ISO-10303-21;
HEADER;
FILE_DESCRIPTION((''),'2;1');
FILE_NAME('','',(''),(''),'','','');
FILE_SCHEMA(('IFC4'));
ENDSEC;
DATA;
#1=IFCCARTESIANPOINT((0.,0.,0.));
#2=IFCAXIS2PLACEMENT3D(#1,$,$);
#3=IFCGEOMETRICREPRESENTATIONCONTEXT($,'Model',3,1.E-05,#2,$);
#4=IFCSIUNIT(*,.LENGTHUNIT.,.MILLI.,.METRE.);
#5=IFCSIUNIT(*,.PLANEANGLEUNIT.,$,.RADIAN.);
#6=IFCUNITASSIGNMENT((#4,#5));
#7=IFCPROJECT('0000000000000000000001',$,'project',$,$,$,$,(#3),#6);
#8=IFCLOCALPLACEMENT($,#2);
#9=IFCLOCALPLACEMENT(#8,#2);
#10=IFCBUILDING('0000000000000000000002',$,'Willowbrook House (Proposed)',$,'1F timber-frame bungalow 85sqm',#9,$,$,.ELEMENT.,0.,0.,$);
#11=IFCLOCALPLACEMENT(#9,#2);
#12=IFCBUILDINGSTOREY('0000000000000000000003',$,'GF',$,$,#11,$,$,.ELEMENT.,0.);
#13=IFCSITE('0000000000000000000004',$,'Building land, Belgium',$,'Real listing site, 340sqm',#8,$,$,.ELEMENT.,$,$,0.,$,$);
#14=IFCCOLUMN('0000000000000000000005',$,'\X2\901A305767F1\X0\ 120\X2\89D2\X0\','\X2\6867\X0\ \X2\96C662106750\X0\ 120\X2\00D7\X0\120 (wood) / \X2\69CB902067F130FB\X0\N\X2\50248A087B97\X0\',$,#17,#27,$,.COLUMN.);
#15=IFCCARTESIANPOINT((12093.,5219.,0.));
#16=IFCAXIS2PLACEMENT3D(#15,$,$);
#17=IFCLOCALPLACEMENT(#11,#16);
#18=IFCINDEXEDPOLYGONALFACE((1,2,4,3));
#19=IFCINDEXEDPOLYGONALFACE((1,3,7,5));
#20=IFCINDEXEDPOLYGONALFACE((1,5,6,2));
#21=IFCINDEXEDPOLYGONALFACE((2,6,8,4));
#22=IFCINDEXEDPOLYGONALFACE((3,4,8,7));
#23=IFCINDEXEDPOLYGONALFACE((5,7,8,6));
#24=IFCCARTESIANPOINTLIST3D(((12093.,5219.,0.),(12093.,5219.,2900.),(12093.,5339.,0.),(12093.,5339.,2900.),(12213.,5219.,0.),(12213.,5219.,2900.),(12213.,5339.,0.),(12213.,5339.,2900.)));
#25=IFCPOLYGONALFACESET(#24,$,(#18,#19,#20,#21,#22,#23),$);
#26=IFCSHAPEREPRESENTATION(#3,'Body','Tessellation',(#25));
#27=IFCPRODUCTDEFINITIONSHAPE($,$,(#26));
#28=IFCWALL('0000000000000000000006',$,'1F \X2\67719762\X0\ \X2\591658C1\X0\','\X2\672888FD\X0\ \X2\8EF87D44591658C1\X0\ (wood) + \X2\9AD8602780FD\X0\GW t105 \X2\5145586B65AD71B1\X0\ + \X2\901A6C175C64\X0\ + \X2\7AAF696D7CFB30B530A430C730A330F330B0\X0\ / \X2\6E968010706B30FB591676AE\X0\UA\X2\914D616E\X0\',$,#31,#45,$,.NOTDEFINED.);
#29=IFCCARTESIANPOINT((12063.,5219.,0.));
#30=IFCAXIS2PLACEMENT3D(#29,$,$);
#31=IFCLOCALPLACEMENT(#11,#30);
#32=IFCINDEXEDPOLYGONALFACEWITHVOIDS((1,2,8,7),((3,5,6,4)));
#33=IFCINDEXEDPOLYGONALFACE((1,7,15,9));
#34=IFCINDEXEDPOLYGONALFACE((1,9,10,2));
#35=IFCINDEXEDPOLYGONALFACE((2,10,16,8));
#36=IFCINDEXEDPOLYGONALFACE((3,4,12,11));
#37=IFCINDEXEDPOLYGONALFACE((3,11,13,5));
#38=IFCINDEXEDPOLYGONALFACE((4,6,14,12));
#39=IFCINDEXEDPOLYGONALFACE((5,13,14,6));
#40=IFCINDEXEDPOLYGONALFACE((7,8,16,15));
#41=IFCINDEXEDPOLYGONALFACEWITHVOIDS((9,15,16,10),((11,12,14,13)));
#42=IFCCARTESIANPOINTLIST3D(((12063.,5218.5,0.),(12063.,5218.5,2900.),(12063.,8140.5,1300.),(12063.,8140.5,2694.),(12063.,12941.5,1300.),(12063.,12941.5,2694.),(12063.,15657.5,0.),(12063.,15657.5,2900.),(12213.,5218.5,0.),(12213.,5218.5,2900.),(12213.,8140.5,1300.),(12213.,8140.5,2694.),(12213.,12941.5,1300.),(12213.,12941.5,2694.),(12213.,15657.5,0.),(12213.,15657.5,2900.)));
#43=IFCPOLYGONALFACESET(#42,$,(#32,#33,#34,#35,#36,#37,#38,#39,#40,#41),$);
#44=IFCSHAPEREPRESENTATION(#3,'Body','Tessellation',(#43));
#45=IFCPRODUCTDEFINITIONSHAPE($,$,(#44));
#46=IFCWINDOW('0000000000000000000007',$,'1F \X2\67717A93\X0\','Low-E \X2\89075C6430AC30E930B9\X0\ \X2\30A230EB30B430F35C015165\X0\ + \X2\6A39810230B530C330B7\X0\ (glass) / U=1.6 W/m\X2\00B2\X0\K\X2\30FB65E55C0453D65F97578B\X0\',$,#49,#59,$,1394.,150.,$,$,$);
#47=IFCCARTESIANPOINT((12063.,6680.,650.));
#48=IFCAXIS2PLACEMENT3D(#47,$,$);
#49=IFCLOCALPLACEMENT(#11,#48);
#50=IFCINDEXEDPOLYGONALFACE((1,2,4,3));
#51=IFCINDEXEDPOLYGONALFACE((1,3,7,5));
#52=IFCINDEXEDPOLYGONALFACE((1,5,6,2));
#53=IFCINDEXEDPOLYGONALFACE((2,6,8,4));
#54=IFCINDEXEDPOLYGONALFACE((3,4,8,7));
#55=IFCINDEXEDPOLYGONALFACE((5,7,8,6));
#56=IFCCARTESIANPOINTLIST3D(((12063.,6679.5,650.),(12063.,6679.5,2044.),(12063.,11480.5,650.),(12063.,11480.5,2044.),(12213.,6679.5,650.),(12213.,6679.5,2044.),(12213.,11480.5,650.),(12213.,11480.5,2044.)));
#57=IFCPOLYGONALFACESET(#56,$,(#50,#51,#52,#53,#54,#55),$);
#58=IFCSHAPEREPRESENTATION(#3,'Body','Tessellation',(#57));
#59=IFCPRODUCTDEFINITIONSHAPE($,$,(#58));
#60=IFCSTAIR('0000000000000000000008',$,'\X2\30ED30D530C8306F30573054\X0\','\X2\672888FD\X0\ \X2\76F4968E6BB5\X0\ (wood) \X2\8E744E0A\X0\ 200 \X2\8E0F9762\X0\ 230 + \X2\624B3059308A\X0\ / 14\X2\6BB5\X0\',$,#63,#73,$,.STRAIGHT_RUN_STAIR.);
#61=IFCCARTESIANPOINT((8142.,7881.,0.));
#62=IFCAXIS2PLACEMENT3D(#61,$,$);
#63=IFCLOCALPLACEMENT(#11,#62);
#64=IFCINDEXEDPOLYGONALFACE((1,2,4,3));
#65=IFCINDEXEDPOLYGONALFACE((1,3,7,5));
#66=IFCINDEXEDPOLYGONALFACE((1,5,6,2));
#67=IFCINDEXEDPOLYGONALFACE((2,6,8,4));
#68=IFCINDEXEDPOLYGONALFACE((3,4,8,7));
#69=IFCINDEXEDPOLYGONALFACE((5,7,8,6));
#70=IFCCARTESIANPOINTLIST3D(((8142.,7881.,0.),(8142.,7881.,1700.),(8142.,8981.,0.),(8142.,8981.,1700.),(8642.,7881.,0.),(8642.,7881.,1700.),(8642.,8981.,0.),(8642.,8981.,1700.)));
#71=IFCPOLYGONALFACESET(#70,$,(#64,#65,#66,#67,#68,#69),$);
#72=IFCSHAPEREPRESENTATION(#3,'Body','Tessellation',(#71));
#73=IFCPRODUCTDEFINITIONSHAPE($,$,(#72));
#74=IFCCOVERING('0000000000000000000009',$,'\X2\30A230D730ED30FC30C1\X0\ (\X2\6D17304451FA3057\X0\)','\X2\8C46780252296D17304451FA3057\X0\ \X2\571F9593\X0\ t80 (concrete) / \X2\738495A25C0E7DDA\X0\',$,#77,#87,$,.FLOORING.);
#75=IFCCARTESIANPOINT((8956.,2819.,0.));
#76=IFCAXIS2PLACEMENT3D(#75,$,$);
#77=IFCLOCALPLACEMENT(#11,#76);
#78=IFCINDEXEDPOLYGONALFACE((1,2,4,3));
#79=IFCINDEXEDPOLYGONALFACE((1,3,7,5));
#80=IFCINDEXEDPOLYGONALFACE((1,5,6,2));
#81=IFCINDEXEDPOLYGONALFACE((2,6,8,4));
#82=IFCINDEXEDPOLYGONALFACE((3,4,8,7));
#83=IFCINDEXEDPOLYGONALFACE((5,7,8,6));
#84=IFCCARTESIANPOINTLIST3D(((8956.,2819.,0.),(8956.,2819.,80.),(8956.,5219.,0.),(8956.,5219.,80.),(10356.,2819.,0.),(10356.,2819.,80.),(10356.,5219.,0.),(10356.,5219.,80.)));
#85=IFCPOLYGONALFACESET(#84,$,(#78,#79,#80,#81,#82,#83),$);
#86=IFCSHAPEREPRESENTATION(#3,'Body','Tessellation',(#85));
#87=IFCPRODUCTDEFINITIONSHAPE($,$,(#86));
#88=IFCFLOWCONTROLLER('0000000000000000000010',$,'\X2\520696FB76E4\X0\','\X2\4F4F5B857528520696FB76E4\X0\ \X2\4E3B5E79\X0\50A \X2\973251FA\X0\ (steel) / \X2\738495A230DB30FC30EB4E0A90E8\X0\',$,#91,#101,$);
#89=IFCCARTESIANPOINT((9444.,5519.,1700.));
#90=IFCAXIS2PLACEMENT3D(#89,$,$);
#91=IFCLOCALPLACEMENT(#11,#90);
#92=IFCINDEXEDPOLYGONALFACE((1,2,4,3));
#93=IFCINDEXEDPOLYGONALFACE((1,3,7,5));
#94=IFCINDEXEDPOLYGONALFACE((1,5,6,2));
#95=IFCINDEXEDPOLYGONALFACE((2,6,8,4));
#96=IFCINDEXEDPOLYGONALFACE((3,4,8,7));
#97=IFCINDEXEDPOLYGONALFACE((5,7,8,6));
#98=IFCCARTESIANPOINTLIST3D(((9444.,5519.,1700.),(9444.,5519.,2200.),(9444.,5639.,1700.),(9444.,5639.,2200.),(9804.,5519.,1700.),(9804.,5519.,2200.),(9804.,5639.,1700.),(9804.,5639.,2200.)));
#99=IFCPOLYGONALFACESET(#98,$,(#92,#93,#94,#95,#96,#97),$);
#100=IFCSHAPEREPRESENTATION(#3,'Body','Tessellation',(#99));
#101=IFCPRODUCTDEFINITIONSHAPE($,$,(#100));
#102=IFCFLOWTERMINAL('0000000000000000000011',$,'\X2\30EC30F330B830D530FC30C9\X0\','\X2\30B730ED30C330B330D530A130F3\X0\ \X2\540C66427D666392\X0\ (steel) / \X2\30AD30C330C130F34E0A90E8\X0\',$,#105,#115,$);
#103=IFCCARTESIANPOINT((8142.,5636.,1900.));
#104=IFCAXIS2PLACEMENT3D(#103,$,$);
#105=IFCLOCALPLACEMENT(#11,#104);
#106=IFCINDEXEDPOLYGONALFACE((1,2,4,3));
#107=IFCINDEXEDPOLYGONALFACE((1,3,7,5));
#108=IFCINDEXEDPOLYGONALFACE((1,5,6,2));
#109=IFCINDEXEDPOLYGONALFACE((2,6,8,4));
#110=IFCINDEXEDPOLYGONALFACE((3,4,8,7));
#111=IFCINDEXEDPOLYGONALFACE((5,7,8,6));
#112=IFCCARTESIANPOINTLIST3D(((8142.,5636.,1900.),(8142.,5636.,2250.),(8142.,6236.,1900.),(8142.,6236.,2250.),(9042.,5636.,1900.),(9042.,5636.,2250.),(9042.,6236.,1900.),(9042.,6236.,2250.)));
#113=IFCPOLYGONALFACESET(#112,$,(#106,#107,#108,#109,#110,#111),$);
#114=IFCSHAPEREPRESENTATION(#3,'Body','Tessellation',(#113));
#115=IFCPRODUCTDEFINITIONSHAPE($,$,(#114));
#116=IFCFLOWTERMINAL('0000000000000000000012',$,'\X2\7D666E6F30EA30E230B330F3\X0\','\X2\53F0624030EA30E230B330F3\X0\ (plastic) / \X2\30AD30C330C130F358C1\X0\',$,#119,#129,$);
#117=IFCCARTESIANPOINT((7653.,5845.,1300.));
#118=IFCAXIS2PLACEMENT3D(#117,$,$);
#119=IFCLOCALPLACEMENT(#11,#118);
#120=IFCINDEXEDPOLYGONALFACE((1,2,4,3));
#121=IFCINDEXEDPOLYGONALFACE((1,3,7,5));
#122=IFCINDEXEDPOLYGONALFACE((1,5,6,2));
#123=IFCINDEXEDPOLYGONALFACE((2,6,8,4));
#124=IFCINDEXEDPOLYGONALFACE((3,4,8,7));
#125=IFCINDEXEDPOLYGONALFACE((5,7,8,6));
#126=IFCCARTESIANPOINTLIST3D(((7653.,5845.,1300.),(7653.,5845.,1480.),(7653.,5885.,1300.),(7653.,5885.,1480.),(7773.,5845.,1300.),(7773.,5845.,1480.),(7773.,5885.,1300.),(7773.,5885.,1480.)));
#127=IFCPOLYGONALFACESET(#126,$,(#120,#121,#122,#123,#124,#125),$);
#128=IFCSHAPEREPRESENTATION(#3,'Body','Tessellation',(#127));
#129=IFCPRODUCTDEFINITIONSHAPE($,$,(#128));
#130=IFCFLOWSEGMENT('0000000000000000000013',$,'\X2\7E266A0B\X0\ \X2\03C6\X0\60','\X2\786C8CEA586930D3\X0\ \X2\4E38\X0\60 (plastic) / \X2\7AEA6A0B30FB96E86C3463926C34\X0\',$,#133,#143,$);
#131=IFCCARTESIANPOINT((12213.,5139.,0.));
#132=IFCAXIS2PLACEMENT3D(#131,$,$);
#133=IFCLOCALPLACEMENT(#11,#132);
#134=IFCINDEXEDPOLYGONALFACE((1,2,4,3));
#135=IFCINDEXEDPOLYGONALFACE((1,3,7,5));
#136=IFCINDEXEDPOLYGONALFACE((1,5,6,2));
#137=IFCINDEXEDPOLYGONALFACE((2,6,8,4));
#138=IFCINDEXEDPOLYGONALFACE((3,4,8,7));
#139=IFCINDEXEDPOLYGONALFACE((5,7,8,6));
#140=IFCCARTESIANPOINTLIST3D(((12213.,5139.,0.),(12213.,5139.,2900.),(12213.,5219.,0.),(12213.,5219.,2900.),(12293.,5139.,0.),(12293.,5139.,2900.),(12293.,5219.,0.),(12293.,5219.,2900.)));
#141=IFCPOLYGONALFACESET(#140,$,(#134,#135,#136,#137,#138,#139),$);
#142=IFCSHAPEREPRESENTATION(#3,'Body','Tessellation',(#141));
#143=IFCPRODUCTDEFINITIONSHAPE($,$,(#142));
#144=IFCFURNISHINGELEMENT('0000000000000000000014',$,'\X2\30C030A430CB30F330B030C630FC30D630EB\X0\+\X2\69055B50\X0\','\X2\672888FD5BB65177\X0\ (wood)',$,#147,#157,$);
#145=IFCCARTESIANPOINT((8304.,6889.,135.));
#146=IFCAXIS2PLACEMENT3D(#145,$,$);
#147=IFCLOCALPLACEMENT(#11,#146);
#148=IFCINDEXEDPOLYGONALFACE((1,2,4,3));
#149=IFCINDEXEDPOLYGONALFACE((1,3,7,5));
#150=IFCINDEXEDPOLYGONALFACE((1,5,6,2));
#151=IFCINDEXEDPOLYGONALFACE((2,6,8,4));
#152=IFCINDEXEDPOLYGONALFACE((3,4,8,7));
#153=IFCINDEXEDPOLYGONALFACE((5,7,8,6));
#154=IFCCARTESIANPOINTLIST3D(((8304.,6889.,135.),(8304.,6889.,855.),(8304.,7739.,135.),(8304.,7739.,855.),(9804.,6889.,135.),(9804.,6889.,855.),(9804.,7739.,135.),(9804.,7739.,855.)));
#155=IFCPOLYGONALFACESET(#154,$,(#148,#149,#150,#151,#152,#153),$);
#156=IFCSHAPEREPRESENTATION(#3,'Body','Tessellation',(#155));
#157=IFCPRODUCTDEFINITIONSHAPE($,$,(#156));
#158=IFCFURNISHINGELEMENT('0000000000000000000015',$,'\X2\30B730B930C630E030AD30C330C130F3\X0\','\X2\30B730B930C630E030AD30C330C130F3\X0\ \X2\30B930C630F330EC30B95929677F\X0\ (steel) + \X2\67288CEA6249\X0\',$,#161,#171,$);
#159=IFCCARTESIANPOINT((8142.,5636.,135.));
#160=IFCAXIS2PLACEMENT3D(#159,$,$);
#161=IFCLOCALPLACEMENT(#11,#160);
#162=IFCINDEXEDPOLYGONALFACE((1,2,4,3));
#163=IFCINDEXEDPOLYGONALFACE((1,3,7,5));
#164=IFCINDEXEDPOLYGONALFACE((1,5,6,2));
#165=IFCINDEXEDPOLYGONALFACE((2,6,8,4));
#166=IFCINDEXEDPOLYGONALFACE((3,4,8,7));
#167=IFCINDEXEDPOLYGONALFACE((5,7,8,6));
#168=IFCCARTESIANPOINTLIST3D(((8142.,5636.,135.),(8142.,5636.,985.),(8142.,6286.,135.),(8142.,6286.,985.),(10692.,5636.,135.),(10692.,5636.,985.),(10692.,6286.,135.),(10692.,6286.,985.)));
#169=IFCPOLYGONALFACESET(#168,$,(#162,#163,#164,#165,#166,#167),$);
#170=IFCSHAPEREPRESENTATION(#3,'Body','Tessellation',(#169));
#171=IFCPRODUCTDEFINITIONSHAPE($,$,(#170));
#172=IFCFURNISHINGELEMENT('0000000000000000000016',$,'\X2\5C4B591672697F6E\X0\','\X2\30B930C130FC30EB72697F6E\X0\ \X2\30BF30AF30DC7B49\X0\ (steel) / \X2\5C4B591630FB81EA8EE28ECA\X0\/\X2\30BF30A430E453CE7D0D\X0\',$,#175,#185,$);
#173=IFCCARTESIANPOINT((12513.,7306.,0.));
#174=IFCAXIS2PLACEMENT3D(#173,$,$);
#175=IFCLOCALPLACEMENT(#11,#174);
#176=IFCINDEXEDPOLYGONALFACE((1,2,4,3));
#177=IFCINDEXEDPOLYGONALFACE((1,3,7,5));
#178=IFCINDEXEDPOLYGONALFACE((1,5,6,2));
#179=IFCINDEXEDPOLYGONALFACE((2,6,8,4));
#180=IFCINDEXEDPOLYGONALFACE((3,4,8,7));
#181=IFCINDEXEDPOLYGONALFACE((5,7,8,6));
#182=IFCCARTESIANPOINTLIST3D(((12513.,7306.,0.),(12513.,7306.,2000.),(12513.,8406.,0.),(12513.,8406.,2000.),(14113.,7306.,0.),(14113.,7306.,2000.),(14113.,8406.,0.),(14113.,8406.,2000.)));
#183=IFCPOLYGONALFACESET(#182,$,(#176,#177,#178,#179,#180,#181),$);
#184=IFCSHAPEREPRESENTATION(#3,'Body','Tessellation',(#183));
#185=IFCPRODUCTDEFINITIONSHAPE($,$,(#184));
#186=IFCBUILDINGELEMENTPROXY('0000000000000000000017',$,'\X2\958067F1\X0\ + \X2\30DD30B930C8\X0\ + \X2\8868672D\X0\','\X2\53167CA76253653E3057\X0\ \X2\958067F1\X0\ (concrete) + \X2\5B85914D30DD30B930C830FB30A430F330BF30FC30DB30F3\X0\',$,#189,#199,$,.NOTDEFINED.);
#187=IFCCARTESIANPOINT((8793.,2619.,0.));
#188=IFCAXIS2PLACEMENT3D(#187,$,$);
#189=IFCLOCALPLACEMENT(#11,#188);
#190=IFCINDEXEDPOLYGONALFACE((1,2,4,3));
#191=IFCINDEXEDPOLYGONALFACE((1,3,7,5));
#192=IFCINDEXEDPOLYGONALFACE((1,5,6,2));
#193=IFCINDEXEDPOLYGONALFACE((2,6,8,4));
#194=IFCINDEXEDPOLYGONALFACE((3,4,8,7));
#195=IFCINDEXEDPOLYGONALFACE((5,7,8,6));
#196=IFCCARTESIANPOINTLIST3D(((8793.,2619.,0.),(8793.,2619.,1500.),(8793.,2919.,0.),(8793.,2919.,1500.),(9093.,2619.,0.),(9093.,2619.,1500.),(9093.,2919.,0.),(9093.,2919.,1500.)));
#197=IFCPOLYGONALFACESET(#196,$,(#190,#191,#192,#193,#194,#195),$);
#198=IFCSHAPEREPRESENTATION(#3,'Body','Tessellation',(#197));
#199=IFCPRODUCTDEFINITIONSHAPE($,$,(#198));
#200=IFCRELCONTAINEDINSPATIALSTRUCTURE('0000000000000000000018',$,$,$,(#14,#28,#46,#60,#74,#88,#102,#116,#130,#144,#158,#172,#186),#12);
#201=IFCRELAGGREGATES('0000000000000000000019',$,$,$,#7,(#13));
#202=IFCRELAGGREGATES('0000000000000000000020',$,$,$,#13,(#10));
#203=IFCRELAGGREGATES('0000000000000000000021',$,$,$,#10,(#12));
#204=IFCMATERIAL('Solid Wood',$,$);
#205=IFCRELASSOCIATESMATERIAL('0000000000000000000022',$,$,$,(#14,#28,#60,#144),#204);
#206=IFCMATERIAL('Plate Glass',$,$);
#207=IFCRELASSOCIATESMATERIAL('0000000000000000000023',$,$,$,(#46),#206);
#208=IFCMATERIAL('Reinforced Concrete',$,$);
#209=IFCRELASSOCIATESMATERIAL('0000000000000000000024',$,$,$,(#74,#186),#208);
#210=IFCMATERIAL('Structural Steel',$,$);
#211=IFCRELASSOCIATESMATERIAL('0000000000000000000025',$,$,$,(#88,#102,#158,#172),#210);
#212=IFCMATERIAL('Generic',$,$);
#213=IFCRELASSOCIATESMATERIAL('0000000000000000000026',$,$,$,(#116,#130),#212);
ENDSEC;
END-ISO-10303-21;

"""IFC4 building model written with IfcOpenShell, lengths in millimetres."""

from ifc_helpers import new_model, si_unit, frame, frame_2d, origin, place, context, project, spatial, rectangle, extrude, material, element, fill, save


model = new_model("IFC4")

# Units and contexts
model_context = context("Model", 3, precision=1e-05, world=origin())
ifc_project = project(units=[si_unit("LENGTHUNIT", "METRE", prefix="MILLI"), si_unit("PLANEANGLEUNIT", "RADIAN")], contexts=[model_context])

# Site, building, storey
site_placement = place(None, origin())
site = spatial("IfcSite", under=ifc_project, at=site_placement, Name="Building land, Belgium", ObjectType="Real listing site, 340sqm", CompositionType="ELEMENT", RefElevation=0.0)
building_placement = place(site_placement, origin())
building = spatial("IfcBuilding", under=site, at=building_placement, Name="Willowbrook House (Proposed)", ObjectType="1F timber-frame bungalow 85sqm", CompositionType="ELEMENT", ElevationOfRefHeight=0.0, ElevationOfTerrain=0.0)
storey_placement = place(building_placement, origin())
storey = spatial("IfcBuildingStorey", under=building, at=storey_placement, Name="GF", CompositionType="ELEMENT", Elevation=0.0)

# Column
ifc_material_1 = material(Name="Solid Wood")
column_1_placement = place(storey_placement, frame((12093.0, 5219.0, 0.0)))
element("IfcColumn", 1, at=column_1_placement, inside=storey, material=ifc_material_1, Name="通し柱 120角", Description="桧 集成材 120×120 (wood) / 構造柱・N値計算", PredefinedType="COLUMN", context=model_context, shape_type="SweptSolid", body=[
    extrude(rectangle(XDim=120.0, YDim=120.0, at=frame_2d((60.0, 60.0))), frame((12093.0, 5219.0, 0.0)), (0.0, 0.0, 1.0), 2900.0),
])

# Wall, opening, window
wall_1_placement = place(storey_placement, frame((12063.0, 5219.0, 0.0)))
wall_1 = element("IfcWall", 2, at=wall_1_placement, inside=storey, material=ifc_material_1, Name="1F 東面 外壁", Description="木製 軸組外壁 (wood) + 高性能GW t105 充填断熱 + 通気層 + 窯業系サイディング / 準耐火・外皮UA配慮", PredefinedType="NOTDEFINED", context=model_context, shape_type="SweptSolid", body=[
    extrude(rectangle(XDim=150.0, YDim=10439.0, at=frame_2d((75.0, 5219.0))), frame((12063.0, 5219.0, 0.0)), (0.0, 0.0, 1.0), 2900.0),
])
opening_placement = place(storey_placement, frame((12063.0, 6680.0, 650.0)))
opening = element("IfcOpeningElement", 3, at=opening_placement, cuts=wall_1, PredefinedType="NOTDEFINED", context=model_context, shape_type="SweptSolid", body=[
    extrude(rectangle(XDim=150.0, YDim=4801.0, at=frame_2d((75.0, 2400.0))), frame((12063.0, 6680.0, 650.0)), (0.0, 0.0, 1.0), 1394.0),
])
ifc_material_2 = material(Name="Plate Glass")
window_placement = place(storey_placement, frame((12063.0, 6680.0, 650.0)))
window = element("IfcWindow", 4, at=window_placement, inside=storey, material=ifc_material_2, Name="1F 東窓", Description="Low-E 複層ガラス アルゴン封入 + 樹脂サッシ (glass) / U=1.6 W/m²K・日射取得型", OverallHeight=1394.0, OverallWidth=150.0, context=model_context, shape_type="SweptSolid", body=[
    extrude(rectangle(XDim=150.0, YDim=4801.0, at=frame_2d((75.0, 2400.0))), frame((12063.0, 6680.0, 650.0)), (0.0, 0.0, 1.0), 1394.0),
])
fill(opening, window)

# Stair
stair_placement = place(storey_placement, frame((8142.0, 7881.0, 0.0)))
element("IfcStair", 5, at=stair_placement, inside=storey, material=ifc_material_1, Name="ロフトはしご", Description="木製 直階段 (wood) 蹴上 200 踏面 230 + 手すり / 14段", PredefinedType="STRAIGHT_RUN_STAIR", context=model_context, shape_type="SweptSolid", body=[
    extrude(rectangle(XDim=500.0, YDim=1100.0, at=frame_2d((250.0, 550.0))), frame((8142.0, 7881.0, 0.0)), (0.0, 0.0, 1.0), 1700.0),
])

# Covering
ifc_material_3 = material(Name="Reinforced Concrete")
covering_placement = place(storey_placement, frame((8956.0, 2819.0, 0.0)))
element("IfcCovering", 6, at=covering_placement, inside=storey, material=ifc_material_3, Name="アプローチ (洗い出し)", Description="豆砂利洗い出し 土間 t80 (concrete) / 玄関導線", PredefinedType="FLOORING", context=model_context, shape_type="SweptSolid", body=[
    extrude(rectangle(XDim=1400.0, YDim=2400.0, at=frame_2d((700.0, 1200.0))), frame((8956.0, 2819.0, 0.0)), (0.0, 0.0, 1.0), 80.0),
])

# Flow controller
ifc_material_4 = material(Name="Structural Steel")
flow_controller_placement = place(storey_placement, frame((9444.0, 5519.0, 1700.0)))
element("IfcFlowController", 7, at=flow_controller_placement, inside=storey, material=ifc_material_4, Name="分電盤", Description="住宅用分電盤 主幹50A 露出 (steel) / 玄関ホール上部", context=model_context, shape_type="SweptSolid", body=[
    extrude(rectangle(XDim=360.0, YDim=120.0, at=frame_2d((180.0, 60.0))), frame((9444.0, 5519.0, 1700.0)), (0.0, 0.0, 1.0), 500.0),
])

# Flow terminals
flow_terminal_1_placement = place(storey_placement, frame((8142.0, 5636.0, 1900.0)))
element("IfcFlowTerminal", 8, at=flow_terminal_1_placement, inside=storey, material=ifc_material_4, Name="レンジフード", Description="シロッコファン 同時給排 (steel) / キッチン上部", context=model_context, shape_type="SweptSolid", body=[
    extrude(rectangle(XDim=900.0, YDim=600.0, at=frame_2d((450.0, 300.0))), frame((8142.0, 5636.0, 1900.0)), (0.0, 0.0, 1.0), 350.0),
])
ifc_material_5 = material(Name="Generic")
flow_terminal_2_placement = place(storey_placement, frame((7653.0, 5845.0, 1300.0)))
element("IfcFlowTerminal", 9, at=flow_terminal_2_placement, inside=storey, material=ifc_material_5, Name="給湯リモコン", Description="台所リモコン (plastic) / キッチン壁", context=model_context, shape_type="SweptSolid", body=[
    extrude(rectangle(XDim=120.0, YDim=40.0, at=frame_2d((60.0, 20.0))), frame((7653.0, 5845.0, 1300.0)), (0.0, 0.0, 1.0), 180.0),
])

# Flow segment
flow_segment_placement = place(storey_placement, frame((12213.0, 5139.0, 0.0)))
element("IfcFlowSegment", 10, at=flow_segment_placement, inside=storey, material=ifc_material_5, Name="縦樋 φ60", Description="硬質塩ビ 丸60 (plastic) / 竪樋・雨水排水", context=model_context, shape_type="SweptSolid", body=[
    extrude(rectangle(XDim=80.0, YDim=80.0, at=frame_2d((40.0, 40.0))), frame((12213.0, 5139.0, 0.0)), (0.0, 0.0, 1.0), 2900.0),
])

# Furnishing elements
furnishing_1_placement = place(storey_placement, frame((8304.0, 6889.0, 135.0)))
element("IfcFurnishingElement", 11, at=furnishing_1_placement, inside=storey, material=ifc_material_1, Name="ダイニングテーブル+椅子", Description="木製家具 (wood)", context=model_context, shape_type="SweptSolid", body=[
    extrude(rectangle(XDim=1500.0, YDim=850.0, at=frame_2d((750.0, 425.0))), frame((8304.0, 6889.0, 135.0)), (0.0, 0.0, 1.0), 720.0),
])
furnishing_2_placement = place(storey_placement, frame((8142.0, 5636.0, 135.0)))
element("IfcFurnishingElement", 12, at=furnishing_2_placement, inside=storey, material=ifc_material_4, Name="システムキッチン", Description="システムキッチン ステンレス天板 (steel) + 木質扉", context=model_context, shape_type="SweptSolid", body=[
    extrude(rectangle(XDim=2550.0, YDim=650.0, at=frame_2d((1275.0, 325.0))), frame((8142.0, 5636.0, 135.0)), (0.0, 0.0, 1.0), 850.0),
])
furnishing_3_placement = place(storey_placement, frame((12513.0, 7306.0, 0.0)))
element("IfcFurnishingElement", 13, at=furnishing_3_placement, inside=storey, material=ifc_material_4, Name="屋外物置", Description="スチール物置 タクボ等 (steel) / 屋外・自転車/タイヤ収納", context=model_context, shape_type="SweptSolid", body=[
    extrude(rectangle(XDim=1600.0, YDim=1100.0, at=frame_2d((800.0, 550.0))), frame((12513.0, 7306.0, 0.0)), (0.0, 0.0, 1.0), 2000.0),
])

# Building element proxy
proxy_placement = place(storey_placement, frame((8793.0, 2619.0, 0.0)))
element("IfcBuildingElementProxy", 14, at=proxy_placement, inside=storey, material=ifc_material_3, Name="門柱 + ポスト + 表札", Description="化粧打放し 門柱 (concrete) + 宅配ポスト・インターホン", PredefinedType="NOTDEFINED", context=model_context, shape_type="SweptSolid", body=[
    extrude(rectangle(XDim=300.0, YDim=300.0, at=frame_2d((150.0, 150.0))), frame((8793.0, 2619.0, 0.0)), (0.0, 0.0, 1.0), 1500.0),
])

save(model, "model.ifc")
